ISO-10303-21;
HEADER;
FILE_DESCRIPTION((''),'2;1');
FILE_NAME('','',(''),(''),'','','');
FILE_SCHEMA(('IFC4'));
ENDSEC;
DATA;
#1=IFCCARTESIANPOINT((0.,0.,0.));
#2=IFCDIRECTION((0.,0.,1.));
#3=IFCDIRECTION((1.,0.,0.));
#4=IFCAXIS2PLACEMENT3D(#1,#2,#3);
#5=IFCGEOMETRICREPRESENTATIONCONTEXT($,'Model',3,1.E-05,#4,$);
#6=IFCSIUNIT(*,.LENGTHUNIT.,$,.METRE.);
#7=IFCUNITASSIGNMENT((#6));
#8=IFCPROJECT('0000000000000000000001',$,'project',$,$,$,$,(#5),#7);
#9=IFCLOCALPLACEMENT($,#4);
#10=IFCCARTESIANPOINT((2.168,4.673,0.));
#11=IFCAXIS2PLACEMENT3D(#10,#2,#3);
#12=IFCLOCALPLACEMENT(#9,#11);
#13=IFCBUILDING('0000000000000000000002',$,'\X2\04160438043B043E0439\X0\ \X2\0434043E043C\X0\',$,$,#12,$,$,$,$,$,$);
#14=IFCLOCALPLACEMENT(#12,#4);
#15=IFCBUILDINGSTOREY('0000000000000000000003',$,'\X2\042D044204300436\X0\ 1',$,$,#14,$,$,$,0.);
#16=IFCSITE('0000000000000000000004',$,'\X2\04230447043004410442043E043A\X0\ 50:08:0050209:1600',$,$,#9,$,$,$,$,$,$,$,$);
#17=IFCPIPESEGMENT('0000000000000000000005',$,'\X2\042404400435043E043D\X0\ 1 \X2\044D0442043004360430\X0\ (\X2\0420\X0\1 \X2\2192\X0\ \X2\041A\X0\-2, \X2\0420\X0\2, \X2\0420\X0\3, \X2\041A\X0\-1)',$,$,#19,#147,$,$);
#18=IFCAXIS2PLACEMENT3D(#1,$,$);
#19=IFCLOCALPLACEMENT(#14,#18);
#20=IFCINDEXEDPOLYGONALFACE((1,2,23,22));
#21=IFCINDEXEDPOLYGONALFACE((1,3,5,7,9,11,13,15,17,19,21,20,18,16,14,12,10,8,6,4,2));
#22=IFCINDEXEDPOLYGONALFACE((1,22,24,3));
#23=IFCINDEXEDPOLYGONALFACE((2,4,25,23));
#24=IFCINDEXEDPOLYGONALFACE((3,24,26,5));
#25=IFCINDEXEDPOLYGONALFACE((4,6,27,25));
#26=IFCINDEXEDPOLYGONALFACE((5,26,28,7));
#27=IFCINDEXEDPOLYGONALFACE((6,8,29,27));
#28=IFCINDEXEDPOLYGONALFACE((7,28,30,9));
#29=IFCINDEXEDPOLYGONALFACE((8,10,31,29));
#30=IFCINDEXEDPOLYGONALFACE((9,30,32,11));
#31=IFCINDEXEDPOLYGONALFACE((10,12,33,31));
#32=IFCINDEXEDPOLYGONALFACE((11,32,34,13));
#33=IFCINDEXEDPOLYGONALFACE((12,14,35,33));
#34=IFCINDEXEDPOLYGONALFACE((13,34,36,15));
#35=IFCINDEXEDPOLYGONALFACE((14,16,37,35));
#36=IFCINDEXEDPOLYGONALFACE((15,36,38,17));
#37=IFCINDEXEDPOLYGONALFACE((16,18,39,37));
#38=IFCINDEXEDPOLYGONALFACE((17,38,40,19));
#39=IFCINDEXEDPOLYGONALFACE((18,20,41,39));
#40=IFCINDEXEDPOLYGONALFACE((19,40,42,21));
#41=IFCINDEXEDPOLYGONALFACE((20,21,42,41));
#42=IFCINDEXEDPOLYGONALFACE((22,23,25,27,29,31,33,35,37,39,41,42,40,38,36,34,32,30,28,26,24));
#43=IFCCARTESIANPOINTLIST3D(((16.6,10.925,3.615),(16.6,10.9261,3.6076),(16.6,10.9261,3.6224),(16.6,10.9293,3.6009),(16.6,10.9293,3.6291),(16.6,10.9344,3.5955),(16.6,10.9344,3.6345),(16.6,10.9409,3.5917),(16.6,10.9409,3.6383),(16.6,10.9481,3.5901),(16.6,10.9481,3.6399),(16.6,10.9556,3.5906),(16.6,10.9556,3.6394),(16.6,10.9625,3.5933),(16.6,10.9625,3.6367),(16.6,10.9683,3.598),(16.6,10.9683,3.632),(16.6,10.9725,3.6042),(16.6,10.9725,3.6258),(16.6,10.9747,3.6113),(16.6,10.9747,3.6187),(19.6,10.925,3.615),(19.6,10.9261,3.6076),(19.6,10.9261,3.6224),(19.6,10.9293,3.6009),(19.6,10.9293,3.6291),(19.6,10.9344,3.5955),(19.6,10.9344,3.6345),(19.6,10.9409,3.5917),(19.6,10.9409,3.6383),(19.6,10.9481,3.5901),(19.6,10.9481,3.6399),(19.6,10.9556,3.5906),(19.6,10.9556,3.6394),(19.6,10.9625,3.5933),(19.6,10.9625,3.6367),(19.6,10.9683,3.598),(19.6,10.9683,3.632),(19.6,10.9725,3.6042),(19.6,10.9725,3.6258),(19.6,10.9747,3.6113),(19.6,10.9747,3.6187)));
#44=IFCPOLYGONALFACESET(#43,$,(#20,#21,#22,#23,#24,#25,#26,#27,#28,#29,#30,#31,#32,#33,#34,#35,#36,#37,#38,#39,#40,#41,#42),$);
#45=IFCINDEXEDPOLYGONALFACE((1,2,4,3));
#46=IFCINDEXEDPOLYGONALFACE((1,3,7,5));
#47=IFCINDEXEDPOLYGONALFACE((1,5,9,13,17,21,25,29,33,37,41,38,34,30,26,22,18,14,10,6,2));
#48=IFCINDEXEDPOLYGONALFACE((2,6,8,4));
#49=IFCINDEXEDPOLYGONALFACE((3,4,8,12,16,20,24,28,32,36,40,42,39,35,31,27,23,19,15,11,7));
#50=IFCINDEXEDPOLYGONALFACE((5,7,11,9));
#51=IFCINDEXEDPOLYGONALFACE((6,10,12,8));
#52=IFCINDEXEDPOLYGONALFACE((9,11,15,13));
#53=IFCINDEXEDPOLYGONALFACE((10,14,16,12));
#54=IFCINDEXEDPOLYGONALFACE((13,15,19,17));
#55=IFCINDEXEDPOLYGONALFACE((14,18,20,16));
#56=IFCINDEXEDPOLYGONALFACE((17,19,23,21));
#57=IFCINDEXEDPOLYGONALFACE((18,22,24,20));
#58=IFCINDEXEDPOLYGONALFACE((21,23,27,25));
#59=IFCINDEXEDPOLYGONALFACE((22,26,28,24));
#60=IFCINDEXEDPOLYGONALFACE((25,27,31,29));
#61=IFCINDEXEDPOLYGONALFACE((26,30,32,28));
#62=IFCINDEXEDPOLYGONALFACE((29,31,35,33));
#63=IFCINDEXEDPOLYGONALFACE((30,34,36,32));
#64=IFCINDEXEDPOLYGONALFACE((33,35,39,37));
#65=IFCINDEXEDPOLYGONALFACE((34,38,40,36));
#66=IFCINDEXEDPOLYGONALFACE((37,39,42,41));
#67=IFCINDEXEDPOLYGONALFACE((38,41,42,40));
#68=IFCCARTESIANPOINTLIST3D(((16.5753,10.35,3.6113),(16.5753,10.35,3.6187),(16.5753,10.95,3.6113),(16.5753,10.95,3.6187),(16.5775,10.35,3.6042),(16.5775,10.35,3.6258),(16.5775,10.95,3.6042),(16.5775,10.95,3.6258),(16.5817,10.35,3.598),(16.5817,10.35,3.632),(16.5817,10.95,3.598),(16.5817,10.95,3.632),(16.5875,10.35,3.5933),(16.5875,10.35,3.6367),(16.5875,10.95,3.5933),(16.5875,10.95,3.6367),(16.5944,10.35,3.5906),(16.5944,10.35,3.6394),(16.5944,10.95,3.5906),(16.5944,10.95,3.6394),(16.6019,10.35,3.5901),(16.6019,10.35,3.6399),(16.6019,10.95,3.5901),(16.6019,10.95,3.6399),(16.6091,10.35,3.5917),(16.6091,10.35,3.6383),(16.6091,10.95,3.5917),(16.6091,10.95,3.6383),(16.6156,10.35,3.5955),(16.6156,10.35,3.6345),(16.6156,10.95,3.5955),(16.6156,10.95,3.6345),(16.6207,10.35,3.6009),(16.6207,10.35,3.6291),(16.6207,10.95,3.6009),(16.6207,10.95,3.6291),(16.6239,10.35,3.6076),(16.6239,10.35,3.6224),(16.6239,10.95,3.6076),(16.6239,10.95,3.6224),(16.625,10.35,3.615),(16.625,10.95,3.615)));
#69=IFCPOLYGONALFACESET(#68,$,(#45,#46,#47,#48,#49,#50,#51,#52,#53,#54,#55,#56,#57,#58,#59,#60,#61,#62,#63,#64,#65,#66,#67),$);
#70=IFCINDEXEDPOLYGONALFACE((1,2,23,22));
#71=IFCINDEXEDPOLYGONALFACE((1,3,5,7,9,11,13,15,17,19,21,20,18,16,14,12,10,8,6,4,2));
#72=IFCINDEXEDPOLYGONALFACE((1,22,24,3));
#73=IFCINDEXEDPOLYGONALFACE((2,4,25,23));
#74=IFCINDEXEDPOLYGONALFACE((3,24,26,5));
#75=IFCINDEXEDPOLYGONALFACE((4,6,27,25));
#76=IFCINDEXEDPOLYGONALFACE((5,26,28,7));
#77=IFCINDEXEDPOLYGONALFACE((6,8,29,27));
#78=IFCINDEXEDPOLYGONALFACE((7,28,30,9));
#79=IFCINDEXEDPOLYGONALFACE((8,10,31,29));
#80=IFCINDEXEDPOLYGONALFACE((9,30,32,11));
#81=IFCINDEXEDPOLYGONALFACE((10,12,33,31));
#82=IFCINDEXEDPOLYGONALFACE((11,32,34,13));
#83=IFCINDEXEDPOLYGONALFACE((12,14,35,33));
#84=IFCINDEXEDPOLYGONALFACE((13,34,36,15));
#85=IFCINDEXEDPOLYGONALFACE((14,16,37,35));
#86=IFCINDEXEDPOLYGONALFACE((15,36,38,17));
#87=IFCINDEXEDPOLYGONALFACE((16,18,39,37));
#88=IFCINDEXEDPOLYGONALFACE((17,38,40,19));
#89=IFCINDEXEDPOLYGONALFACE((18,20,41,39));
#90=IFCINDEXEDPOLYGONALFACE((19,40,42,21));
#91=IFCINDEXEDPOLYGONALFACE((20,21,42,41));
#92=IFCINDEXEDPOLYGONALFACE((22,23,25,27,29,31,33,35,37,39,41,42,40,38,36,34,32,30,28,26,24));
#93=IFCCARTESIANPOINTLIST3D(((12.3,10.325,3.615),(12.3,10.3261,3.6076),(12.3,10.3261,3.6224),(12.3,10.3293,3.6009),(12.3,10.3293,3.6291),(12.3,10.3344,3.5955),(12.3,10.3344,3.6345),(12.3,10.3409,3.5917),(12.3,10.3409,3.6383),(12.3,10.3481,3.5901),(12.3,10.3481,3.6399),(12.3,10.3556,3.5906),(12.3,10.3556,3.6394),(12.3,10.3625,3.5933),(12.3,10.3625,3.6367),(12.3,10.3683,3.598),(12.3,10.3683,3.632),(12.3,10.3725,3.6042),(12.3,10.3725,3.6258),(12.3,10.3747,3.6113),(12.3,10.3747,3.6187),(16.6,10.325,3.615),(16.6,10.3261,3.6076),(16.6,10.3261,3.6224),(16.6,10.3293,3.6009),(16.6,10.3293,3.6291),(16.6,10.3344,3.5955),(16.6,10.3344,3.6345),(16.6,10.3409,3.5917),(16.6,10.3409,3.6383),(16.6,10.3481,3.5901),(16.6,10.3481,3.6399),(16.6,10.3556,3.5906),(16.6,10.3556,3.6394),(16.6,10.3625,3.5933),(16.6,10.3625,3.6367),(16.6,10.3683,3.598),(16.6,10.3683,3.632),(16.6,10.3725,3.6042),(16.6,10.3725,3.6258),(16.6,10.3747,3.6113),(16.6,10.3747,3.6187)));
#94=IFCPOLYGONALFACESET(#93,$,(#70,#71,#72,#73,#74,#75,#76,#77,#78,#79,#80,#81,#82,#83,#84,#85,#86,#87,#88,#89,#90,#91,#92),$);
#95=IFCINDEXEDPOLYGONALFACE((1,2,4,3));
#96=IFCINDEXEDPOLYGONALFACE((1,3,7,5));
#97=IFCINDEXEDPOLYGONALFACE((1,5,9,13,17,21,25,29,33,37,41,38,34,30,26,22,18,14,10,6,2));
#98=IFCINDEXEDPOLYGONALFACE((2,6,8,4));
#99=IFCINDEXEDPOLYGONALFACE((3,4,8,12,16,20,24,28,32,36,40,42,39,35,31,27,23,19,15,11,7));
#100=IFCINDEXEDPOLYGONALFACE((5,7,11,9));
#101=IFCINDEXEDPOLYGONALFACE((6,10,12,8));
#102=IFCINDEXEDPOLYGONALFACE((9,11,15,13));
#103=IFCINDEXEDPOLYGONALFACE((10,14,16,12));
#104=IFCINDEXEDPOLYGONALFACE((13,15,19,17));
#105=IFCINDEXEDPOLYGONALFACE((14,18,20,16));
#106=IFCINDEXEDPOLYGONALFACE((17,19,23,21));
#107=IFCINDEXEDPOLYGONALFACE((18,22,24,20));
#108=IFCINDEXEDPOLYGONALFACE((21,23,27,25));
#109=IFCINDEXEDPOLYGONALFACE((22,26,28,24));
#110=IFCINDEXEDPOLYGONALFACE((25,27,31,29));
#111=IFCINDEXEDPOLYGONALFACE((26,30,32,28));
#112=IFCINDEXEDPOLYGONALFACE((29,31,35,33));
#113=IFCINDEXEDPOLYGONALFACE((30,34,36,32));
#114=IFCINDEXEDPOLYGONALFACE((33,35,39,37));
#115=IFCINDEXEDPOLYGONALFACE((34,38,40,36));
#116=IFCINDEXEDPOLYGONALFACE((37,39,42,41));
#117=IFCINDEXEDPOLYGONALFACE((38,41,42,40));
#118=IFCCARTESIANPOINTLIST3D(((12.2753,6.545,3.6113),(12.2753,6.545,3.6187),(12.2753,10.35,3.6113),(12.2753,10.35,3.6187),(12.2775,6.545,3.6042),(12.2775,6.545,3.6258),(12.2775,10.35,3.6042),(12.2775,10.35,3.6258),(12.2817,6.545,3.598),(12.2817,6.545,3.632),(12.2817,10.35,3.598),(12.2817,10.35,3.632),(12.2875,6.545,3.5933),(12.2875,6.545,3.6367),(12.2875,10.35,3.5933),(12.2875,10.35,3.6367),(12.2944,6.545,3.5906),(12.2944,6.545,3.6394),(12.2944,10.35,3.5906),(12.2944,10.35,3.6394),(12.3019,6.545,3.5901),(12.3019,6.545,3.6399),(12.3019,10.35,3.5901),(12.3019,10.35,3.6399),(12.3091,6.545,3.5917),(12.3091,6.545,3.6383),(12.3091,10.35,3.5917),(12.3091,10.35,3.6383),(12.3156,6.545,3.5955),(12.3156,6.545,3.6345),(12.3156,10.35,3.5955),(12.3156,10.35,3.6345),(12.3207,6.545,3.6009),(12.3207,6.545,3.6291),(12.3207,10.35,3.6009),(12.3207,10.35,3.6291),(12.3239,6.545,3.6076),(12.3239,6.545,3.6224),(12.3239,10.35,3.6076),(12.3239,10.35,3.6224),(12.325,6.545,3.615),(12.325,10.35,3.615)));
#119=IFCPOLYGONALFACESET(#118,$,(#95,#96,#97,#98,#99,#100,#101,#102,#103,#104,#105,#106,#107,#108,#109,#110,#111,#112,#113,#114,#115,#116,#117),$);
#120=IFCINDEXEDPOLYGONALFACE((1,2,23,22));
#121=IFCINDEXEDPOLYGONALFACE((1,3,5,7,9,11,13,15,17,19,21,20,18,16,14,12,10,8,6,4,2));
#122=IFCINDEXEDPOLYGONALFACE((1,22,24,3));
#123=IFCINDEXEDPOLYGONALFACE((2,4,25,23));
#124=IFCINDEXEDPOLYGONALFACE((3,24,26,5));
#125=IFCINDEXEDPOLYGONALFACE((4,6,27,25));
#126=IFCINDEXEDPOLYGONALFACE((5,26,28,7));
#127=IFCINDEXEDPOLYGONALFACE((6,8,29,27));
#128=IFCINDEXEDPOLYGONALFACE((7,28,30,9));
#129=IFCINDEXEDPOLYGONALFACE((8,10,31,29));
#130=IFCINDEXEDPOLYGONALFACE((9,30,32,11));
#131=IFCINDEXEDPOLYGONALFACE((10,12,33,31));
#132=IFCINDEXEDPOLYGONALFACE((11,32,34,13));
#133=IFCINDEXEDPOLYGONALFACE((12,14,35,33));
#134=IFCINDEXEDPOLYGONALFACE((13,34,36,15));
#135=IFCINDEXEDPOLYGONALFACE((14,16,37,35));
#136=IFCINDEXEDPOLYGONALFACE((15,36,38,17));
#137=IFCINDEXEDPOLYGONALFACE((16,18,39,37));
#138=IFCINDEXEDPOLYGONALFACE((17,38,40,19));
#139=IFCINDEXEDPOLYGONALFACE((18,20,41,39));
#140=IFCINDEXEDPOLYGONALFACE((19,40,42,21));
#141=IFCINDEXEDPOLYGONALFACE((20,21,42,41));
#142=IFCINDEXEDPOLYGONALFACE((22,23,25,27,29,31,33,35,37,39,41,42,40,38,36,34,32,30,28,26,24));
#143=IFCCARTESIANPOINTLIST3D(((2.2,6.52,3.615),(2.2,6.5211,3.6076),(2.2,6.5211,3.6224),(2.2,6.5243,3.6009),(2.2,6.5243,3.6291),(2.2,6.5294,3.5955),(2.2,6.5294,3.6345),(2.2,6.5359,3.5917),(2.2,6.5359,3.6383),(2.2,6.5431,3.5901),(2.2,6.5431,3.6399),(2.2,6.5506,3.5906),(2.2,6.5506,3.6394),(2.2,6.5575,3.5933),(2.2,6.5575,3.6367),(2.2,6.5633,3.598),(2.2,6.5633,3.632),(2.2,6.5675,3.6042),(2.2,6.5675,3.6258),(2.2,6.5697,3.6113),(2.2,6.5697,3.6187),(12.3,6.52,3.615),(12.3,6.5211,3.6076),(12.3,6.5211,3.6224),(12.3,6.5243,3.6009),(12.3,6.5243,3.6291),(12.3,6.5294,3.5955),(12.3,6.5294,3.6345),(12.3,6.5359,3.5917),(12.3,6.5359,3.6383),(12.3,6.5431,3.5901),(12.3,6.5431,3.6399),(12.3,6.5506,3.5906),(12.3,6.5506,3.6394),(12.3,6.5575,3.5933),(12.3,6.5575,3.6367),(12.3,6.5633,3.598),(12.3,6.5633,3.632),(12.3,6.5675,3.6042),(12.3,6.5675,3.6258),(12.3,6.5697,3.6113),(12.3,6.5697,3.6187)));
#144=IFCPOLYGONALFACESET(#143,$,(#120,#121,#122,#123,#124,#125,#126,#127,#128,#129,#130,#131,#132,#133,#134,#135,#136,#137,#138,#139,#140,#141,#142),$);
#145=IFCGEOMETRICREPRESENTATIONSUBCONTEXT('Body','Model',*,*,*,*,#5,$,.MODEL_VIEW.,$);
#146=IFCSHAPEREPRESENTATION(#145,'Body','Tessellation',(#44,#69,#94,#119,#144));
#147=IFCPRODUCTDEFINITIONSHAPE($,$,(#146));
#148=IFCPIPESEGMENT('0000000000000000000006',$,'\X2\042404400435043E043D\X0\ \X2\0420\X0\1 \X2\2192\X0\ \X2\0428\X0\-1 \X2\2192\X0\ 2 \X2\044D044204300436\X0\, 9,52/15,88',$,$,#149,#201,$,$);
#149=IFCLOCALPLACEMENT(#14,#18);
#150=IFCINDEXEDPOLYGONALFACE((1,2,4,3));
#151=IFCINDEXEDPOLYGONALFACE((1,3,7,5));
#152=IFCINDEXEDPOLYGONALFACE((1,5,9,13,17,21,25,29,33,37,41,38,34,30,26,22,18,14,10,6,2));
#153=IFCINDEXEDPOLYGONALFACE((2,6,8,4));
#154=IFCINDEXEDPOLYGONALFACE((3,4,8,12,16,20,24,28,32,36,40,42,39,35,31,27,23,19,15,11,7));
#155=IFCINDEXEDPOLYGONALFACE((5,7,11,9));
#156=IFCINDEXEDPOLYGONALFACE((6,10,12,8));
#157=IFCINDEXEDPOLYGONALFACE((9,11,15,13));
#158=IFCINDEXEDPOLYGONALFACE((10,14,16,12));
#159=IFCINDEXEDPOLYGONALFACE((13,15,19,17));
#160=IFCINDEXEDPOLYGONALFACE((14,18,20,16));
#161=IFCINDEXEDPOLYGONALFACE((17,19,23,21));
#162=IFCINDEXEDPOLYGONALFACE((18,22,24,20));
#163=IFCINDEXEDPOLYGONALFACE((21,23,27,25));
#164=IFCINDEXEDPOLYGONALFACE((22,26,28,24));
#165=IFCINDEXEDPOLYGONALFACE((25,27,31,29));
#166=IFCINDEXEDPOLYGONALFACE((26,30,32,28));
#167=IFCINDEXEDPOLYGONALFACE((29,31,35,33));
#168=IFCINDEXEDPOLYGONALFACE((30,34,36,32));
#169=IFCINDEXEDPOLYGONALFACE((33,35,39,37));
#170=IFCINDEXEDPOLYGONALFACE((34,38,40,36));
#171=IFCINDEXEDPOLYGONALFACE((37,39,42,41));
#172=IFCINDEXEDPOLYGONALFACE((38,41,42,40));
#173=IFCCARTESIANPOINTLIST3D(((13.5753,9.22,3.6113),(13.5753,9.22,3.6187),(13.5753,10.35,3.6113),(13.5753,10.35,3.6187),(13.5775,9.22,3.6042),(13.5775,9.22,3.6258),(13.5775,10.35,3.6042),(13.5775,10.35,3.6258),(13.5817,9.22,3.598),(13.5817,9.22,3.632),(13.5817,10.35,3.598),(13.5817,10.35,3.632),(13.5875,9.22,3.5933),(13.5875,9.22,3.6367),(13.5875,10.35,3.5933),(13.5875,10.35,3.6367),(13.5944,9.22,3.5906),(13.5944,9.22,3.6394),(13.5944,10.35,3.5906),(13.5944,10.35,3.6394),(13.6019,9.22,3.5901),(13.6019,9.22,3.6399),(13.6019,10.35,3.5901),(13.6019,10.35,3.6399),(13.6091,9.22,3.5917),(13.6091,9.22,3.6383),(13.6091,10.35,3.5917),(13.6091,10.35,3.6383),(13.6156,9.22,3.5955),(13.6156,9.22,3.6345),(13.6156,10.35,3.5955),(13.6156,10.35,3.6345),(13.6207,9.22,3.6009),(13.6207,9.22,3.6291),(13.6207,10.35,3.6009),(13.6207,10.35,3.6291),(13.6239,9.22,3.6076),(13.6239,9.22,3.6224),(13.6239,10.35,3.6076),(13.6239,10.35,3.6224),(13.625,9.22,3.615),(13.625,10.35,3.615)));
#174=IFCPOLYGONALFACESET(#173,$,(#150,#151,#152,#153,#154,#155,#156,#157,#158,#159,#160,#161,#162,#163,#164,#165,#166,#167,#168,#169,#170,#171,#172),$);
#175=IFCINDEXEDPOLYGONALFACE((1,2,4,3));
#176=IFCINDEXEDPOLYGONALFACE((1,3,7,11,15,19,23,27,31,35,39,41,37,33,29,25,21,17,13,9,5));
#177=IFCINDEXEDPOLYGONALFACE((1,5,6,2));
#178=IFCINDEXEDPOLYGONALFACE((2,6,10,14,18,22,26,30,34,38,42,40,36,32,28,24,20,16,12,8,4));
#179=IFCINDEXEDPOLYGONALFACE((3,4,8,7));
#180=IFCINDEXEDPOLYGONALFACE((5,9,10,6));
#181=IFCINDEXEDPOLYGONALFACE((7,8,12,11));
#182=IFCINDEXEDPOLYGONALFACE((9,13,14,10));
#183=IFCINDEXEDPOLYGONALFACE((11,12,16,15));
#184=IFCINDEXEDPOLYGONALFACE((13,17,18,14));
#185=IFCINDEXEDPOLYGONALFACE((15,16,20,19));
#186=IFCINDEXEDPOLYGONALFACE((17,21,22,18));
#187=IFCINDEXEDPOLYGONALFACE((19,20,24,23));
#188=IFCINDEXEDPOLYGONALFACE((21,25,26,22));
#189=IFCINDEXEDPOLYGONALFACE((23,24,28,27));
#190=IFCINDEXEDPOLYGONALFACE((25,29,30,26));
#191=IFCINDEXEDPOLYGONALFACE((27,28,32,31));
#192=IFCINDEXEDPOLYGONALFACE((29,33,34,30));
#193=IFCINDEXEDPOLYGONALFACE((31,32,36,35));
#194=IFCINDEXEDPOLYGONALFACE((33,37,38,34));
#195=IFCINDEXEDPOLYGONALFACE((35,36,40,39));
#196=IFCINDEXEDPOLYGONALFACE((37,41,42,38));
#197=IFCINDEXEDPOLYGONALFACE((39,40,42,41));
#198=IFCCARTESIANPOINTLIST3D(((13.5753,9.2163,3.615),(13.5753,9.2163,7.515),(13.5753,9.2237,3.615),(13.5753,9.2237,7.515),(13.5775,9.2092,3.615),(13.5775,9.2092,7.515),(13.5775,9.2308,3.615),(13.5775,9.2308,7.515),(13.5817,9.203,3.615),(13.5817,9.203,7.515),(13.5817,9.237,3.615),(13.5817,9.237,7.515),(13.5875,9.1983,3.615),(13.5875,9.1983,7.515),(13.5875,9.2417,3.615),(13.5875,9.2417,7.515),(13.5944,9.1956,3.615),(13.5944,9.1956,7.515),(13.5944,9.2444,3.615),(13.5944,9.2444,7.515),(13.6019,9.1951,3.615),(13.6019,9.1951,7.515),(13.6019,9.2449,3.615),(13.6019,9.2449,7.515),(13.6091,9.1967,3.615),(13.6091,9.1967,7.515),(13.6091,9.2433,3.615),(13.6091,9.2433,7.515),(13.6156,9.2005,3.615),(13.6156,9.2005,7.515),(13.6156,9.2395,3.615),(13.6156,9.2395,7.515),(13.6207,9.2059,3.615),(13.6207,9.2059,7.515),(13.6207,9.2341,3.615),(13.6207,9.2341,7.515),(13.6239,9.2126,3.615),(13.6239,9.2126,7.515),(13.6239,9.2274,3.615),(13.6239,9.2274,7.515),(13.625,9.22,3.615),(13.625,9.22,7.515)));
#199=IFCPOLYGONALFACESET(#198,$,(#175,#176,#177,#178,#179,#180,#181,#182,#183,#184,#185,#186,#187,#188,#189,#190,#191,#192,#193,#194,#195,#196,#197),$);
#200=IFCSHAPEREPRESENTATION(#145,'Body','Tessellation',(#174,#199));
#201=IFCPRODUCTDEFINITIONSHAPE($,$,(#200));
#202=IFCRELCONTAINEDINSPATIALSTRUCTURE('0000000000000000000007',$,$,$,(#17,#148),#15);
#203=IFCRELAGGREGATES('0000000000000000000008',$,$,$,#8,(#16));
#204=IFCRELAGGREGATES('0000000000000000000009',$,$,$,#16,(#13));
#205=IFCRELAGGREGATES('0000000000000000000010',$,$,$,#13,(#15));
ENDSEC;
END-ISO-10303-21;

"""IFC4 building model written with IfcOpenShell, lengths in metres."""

from ifc_helpers import new_model, si_unit, frame, origin_with_axes, origin_2d, place, context, subcontext, project, spatial, circle, extrude, element, save


model = new_model("IFC4")

# Units and contexts
model_context = context("Model", 3, precision=1e-05, world=origin_with_axes())
body_context = subcontext(model_context, "Body", "Model", "MODEL_VIEW")
ifc_project = project(units=[si_unit("LENGTHUNIT", "METRE")], contexts=[model_context])

# Site, building, storey
site_placement = place(None, origin_with_axes())
site = spatial("IfcSite", under=ifc_project, at=site_placement, Name="Участок 50:08:0050209:1600")
building_placement = place(site_placement, frame((2.168, 4.673, 0.0), z_axis=(0.0, 0.0, 1.0), x_axis=(1.0, 0.0, 0.0)))
building = spatial("IfcBuilding", under=site, at=building_placement, Name="Жилой дом")
storey_placement = place(building_placement, origin_with_axes())
storey = spatial("IfcBuildingStorey", under=building, at=storey_placement, Name="Этаж 1", Elevation=0.0)

# Pipe segments
pipe_segment_1_placement = place(storey_placement, origin_with_axes())
element("IfcPipeSegment", 1, at=pipe_segment_1_placement, inside=storey, Name="Фреон 1 этажа (Р1 → К-2, Р2, Р3, К-1)", context=body_context, shape_type="SweptSolid", body=[
    extrude(circle(Radius=0.025, at=origin_2d()), frame((19.6, 10.95, 3.615), z_axis=(-1.0, 0.0, 0.0), x_axis=(0.0, -1.0, 0.0)), (0.0, 0.0, 1.0), 3.0),
    extrude(circle(Radius=0.025, at=origin_2d()), frame((16.6, 10.95, 3.615), z_axis=(0.0, -1.0, 0.0), x_axis=(1.0, 0.0, 0.0)), (0.0, 0.0, 1.0), 0.6),
    extrude(circle(Radius=0.025, at=origin_2d()), frame((16.6, 10.35, 3.615), z_axis=(-1.0, 0.0, 0.0), x_axis=(0.0, -1.0, 0.0)), (0.0, 0.0, 1.0), 4.3),
    extrude(circle(Radius=0.025, at=origin_2d()), frame((12.3, 10.35, 3.615), z_axis=(0.0, -1.0, 0.0), x_axis=(1.0, 0.0, 0.0)), (0.0, 0.0, 1.0), 3.805),
    extrude(circle(Radius=0.025, at=origin_2d()), frame((12.3, 6.545, 3.615), z_axis=(-1.0, 0.0, 0.0), x_axis=(0.0, -1.0, 0.0)), (0.0, 0.0, 1.0), 10.1),
])
pipe_segment_2_placement = place(storey_placement, origin_with_axes())
element("IfcPipeSegment", 2, at=pipe_segment_2_placement, inside=storey, Name="Фреон Р1 → Ш-1 → 2 этаж, 9,52/15,88", context=body_context, shape_type="SweptSolid", body=[
    extrude(circle(Radius=0.025, at=origin_2d()), frame((13.6, 10.35, 3.615), z_axis=(0.0, -1.0, 0.0), x_axis=(1.0, 0.0, 0.0)), (0.0, 0.0, 1.0), 1.13),
    extrude(circle(Radius=0.025, at=origin_2d()), frame((13.6, 9.22, 3.615), z_axis=(0.0, 0.0, 1.0), x_axis=(1.0, 0.0, 0.0)), (0.0, 0.0, 1.0), 3.9),
])

save(model, "model.ifc")
